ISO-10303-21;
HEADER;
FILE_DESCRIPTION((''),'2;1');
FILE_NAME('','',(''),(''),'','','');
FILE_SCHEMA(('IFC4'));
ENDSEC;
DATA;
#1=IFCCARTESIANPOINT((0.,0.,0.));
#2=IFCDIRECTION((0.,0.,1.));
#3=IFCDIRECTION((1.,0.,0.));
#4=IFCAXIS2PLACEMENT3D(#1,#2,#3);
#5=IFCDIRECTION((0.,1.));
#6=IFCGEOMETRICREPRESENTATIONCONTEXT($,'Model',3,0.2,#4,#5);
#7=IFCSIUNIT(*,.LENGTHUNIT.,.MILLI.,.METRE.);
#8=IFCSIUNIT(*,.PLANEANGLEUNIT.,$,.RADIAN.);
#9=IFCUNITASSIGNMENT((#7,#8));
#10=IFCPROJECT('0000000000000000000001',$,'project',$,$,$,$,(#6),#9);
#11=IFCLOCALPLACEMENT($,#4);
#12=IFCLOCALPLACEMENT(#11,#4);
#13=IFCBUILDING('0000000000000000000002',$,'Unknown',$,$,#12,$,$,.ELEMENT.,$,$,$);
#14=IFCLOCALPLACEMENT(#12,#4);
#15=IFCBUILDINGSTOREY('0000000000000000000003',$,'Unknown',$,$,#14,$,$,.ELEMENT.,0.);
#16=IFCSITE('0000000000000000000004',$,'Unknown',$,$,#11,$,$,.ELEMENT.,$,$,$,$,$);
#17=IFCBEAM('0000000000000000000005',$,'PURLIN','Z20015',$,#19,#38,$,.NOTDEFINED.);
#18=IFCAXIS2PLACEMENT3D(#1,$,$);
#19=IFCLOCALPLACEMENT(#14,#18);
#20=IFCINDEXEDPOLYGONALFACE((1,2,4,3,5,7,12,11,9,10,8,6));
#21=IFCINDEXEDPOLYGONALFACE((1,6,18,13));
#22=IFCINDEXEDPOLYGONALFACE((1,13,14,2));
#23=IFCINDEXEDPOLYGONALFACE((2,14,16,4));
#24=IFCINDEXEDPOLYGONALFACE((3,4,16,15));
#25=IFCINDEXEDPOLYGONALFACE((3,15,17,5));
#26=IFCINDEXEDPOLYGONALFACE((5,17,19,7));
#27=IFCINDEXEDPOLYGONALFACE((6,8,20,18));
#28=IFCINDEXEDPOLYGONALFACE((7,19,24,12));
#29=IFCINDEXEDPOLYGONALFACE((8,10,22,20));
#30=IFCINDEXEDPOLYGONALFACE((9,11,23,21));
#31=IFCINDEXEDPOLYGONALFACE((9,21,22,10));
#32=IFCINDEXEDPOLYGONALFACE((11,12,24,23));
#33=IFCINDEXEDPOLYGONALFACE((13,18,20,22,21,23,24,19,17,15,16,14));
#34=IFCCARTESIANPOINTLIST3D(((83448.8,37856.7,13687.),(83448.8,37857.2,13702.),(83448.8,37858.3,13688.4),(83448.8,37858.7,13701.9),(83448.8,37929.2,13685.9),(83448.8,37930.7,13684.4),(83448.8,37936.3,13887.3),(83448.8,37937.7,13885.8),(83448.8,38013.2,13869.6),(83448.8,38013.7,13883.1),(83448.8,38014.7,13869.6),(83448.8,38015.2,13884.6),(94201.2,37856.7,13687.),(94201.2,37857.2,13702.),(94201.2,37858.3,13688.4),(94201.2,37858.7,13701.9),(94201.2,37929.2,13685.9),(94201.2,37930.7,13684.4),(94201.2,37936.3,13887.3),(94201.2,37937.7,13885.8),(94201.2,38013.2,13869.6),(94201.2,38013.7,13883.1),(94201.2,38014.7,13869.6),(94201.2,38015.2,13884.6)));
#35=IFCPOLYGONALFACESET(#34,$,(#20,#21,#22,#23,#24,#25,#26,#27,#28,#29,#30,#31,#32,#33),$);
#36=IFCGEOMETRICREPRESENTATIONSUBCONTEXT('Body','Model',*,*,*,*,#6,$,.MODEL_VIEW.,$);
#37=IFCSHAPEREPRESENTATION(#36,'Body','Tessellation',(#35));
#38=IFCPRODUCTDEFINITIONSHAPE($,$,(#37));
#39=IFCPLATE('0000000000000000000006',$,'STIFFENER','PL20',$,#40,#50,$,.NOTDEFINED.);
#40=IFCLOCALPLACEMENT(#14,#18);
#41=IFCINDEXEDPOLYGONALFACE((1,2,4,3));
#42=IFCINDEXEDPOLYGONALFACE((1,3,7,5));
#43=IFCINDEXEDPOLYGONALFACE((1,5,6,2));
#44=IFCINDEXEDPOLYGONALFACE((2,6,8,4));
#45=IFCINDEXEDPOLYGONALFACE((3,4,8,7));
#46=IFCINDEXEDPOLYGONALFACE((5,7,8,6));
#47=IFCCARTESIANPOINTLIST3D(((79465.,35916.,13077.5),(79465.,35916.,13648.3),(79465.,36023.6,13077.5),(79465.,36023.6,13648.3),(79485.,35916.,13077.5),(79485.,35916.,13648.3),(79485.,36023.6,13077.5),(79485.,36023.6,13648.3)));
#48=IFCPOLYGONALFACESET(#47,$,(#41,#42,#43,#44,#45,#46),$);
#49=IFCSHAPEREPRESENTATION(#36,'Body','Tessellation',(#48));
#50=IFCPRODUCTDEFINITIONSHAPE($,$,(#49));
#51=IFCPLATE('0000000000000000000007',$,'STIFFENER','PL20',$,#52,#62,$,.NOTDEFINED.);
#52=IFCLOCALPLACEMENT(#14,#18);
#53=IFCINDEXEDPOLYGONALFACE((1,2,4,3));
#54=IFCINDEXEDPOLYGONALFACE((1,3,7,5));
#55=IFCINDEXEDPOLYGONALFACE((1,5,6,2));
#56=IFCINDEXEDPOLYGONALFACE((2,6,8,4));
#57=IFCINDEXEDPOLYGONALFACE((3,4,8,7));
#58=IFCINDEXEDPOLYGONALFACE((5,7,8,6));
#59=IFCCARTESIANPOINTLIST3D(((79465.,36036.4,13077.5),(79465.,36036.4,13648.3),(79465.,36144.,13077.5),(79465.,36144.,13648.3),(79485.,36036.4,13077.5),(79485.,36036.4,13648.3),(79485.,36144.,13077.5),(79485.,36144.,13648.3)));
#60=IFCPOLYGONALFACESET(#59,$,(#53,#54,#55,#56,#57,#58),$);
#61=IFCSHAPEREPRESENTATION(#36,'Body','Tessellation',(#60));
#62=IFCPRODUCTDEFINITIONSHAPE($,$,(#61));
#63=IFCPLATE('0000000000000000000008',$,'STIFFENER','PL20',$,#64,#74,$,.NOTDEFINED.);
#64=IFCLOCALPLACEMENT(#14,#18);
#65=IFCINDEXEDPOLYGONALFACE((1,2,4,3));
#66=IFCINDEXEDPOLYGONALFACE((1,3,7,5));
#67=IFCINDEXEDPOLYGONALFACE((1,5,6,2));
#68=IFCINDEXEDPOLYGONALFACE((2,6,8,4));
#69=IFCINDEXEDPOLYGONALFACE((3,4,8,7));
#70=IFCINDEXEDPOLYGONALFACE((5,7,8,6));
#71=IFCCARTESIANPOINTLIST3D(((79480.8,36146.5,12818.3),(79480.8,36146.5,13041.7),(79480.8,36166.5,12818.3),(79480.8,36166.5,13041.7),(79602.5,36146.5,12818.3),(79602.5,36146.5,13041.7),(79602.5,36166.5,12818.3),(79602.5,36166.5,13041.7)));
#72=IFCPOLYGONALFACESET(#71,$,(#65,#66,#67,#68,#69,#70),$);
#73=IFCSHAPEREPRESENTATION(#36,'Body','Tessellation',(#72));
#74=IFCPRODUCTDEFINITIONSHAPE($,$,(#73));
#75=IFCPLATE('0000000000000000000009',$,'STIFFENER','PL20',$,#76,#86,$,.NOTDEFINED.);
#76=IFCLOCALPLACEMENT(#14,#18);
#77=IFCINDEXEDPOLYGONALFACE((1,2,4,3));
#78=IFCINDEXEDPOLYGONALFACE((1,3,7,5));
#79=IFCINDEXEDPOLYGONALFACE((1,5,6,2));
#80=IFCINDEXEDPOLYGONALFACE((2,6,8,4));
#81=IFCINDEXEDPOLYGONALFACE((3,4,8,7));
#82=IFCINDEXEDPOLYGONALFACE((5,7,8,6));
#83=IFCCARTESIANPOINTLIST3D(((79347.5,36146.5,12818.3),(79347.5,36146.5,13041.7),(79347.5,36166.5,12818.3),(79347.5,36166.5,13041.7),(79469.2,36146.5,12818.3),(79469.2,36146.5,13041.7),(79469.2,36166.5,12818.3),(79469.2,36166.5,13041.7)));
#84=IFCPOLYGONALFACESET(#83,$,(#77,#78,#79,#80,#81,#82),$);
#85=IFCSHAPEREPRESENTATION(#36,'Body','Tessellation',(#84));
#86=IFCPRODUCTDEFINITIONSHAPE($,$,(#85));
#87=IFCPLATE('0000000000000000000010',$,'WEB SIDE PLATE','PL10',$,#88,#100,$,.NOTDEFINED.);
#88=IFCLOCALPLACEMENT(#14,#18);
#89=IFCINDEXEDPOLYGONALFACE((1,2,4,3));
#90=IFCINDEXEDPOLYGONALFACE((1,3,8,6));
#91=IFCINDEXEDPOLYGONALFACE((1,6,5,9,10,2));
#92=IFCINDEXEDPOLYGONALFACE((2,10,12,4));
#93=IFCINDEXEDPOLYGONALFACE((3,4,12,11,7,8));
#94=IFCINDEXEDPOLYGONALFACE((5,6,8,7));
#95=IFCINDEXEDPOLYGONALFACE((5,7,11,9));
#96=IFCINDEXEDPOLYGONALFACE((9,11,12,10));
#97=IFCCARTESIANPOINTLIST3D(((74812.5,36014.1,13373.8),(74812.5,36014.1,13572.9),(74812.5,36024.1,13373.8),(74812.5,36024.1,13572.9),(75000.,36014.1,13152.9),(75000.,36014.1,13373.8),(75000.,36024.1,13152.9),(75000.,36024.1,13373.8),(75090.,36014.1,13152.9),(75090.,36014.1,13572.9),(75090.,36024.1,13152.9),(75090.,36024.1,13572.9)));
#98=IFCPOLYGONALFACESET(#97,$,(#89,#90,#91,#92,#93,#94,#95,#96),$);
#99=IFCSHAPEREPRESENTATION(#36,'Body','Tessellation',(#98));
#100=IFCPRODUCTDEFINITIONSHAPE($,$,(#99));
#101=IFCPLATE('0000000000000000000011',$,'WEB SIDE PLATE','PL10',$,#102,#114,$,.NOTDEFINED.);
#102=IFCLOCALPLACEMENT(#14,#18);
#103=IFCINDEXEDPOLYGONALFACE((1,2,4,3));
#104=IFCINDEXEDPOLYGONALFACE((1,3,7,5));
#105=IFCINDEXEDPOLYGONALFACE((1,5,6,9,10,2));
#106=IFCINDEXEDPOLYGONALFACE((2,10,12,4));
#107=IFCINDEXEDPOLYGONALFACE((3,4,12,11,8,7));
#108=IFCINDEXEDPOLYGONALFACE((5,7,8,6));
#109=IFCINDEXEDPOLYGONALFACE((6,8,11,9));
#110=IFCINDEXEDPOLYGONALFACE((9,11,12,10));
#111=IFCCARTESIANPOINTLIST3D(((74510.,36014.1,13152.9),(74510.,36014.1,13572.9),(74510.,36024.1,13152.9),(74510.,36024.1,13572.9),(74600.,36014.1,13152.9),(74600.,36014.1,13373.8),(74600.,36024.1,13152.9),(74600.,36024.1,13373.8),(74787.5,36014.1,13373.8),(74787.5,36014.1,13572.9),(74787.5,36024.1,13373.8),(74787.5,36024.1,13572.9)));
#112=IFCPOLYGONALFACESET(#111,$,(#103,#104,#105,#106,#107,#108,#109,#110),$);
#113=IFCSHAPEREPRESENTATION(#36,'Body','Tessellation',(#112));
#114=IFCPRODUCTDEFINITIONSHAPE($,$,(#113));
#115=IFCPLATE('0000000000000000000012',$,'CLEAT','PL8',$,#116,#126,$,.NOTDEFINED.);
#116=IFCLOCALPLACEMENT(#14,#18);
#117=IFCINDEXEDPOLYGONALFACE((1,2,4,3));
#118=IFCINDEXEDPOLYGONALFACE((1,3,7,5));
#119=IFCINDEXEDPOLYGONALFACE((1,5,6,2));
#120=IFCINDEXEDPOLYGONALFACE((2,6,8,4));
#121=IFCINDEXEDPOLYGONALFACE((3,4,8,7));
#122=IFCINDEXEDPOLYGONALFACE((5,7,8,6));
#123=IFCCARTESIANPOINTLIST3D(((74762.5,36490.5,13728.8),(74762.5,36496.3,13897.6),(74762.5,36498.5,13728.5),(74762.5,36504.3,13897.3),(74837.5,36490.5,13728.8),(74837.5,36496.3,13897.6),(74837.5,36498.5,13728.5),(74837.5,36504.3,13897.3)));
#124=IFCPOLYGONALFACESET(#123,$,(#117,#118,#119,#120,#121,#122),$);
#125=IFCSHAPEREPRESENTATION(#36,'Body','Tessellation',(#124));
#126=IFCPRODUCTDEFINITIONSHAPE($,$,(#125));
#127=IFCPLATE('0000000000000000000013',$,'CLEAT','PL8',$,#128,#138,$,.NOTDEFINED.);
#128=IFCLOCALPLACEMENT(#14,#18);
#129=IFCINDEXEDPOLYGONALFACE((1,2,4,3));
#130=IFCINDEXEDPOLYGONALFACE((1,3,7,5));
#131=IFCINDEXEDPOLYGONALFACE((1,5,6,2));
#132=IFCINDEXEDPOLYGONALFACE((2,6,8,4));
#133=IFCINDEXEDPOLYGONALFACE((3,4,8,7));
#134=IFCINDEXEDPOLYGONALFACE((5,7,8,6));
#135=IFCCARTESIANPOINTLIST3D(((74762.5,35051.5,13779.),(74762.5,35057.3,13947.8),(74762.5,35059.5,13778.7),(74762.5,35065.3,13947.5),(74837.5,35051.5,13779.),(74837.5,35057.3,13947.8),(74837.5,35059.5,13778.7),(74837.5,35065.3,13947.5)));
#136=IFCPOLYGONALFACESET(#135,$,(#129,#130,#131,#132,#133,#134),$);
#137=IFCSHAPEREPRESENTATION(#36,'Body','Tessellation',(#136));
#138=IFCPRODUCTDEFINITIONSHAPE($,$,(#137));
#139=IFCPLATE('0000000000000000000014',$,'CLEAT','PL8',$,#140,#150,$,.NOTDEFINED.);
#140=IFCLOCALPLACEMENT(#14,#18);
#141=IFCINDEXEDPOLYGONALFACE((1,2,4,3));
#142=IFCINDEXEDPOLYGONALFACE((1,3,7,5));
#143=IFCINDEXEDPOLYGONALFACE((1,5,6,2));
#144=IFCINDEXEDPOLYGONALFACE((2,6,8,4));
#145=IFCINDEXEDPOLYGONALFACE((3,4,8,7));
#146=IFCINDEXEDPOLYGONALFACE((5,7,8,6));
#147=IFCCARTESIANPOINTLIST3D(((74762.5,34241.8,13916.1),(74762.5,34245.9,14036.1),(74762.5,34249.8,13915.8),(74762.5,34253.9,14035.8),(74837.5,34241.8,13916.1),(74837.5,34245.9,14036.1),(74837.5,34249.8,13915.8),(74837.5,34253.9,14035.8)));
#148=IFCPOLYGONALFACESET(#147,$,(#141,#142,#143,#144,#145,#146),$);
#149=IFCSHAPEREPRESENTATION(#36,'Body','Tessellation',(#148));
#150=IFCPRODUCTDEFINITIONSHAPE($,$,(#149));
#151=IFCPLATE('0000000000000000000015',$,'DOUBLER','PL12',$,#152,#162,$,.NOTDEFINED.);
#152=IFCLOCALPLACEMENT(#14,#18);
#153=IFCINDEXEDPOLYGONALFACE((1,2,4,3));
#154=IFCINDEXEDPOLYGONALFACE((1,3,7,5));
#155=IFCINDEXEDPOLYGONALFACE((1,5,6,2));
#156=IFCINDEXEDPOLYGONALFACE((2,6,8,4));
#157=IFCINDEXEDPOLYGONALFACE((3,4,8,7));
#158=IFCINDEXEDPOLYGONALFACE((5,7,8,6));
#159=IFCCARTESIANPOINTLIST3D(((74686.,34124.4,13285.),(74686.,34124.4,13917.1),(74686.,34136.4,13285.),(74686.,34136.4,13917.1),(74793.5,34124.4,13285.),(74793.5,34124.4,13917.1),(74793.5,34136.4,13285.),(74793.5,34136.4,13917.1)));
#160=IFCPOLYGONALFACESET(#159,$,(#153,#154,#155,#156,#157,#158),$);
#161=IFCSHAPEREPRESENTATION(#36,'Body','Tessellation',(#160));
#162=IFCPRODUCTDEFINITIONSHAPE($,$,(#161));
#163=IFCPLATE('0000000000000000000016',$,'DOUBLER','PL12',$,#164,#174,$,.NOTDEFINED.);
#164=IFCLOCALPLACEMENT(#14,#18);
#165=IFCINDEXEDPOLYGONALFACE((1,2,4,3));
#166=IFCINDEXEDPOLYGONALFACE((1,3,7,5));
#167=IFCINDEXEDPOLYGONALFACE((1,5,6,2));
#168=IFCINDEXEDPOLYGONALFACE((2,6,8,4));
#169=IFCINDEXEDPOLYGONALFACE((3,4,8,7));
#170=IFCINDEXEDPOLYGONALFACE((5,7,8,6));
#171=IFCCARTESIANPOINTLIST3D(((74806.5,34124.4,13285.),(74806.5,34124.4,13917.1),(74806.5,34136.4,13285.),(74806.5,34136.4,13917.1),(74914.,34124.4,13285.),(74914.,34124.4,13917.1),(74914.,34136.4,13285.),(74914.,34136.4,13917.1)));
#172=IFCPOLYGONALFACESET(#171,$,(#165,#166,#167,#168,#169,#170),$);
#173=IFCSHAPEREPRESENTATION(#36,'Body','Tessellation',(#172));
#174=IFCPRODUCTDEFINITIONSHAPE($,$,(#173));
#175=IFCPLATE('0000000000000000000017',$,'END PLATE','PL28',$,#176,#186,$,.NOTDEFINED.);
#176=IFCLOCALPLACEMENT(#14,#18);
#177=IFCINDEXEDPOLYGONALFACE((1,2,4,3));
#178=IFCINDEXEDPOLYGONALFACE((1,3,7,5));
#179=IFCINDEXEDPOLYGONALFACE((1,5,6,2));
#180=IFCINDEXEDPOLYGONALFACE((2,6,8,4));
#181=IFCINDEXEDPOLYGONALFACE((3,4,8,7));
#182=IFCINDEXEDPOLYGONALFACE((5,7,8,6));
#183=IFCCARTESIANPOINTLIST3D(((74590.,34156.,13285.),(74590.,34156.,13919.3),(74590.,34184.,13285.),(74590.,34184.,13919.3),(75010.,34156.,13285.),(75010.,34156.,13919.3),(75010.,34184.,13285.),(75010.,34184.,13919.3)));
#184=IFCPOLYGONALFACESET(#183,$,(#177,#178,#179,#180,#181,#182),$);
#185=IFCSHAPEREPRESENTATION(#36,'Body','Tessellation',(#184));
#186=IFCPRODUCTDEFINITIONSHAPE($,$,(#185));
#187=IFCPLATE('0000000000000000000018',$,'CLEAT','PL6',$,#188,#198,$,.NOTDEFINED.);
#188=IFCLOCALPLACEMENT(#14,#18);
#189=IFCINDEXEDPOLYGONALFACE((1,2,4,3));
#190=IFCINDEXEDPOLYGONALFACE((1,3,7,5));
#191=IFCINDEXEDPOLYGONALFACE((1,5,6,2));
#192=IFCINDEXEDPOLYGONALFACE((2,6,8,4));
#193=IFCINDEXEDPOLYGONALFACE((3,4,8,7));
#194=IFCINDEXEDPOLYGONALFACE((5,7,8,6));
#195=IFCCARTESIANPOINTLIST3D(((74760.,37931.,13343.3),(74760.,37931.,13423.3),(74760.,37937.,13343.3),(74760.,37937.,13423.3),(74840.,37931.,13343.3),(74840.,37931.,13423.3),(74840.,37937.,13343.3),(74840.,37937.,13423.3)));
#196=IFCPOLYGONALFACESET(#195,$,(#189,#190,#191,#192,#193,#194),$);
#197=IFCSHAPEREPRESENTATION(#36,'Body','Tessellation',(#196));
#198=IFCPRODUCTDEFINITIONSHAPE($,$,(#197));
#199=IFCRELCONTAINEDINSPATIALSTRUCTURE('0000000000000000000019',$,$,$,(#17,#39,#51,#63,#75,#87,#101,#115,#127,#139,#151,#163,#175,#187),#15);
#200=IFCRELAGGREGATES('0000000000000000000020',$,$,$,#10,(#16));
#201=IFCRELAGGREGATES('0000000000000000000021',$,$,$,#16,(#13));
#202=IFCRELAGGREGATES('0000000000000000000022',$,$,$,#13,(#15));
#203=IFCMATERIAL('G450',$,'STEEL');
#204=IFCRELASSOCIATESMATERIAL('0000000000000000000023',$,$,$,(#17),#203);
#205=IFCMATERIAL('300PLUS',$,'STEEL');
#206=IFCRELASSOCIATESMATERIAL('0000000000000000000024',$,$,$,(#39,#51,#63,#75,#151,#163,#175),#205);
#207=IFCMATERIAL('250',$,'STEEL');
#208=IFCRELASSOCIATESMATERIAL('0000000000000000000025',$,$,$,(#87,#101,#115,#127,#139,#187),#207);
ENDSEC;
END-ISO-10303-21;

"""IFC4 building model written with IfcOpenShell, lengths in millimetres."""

from ifc_helpers import new_model, si_unit, direction, frame, origin_with_axes, place, context, subcontext, project, spatial, line, indexed_curve, outline, extrude, material, element, save


model = new_model("IFC4")

# Units and contexts
model_context = context("Model", 3, precision=0.2, world=origin_with_axes(), true_north=direction((0.0, 1.0)))
body_context = subcontext(model_context, "Body", "Model", "MODEL_VIEW")
ifc_project = project(units=[si_unit("LENGTHUNIT", "METRE", prefix="MILLI"), si_unit("PLANEANGLEUNIT", "RADIAN")], contexts=[model_context])

# Site, building, storey
site_placement = place(None, origin_with_axes())
site = spatial("IfcSite", under=ifc_project, at=site_placement, Name="Unknown", CompositionType="ELEMENT")
building_placement = place(site_placement, origin_with_axes())
building = spatial("IfcBuilding", under=site, at=building_placement, Name="Unknown", CompositionType="ELEMENT")
storey_placement = place(building_placement, origin_with_axes())
storey = spatial("IfcBuildingStorey", under=building, at=storey_placement, Name="Unknown", CompositionType="ELEMENT", Elevation=0.0)

# Beam
ifc_material_1 = material(Name="300PLUS", Category="STEEL")
ifc_material_2 = material(Name="G450", Category="STEEL")
for number, where, z_axis, x_axis, name in (
    (1, (83448.8, 37933.5, 13785.9), (0.0, -0.999391, 0.034899), (1.0, 0.0, 0.0), "PURLIN"),
):
    element("IfcBeam", number, at=place(storey_placement, frame(where, z_axis=z_axis, x_axis=x_axis)), inside=storey, material=ifc_material_2, Name=name, Description="Z20015", PredefinedType="NOTDEFINED", context=body_context, shape_type="SolidModel", body=[
        extrude(outline(indexed_curve([(73.2, -101.5), (73.2, -86.5), (71.8, -86.5), (71.8, -100.0), (0.8, -100.0), (0.8, 101.5), (-78.2, 101.5), (-78.2, 86.5), (-76.8, 86.5), (-76.8, 100.0), (-0.8, 100.0), (-0.8, -101.5)], segments=[line(1, 2, 3, 4, 5, 6, 7, 8, 9, 10, 11, 12, 1)])), frame((0.0, 0.0, 0.0), z_axis=(-1.0, 0.0, 0.0), x_axis=(0.0, 0.0, 1.0)), (0.0, 0.0, -1.0), 10752.4),
    ])

# Plates
for number, where, z_axis, x_axis, name in (
    (2, (79475.0, 36023.6, 13077.5), (1.0, 0.0, 0.0), (0.0, 0.0, 1.0), "STIFFENER"),
    (3, (79475.0, 36144.0, 13077.5), (1.0, 0.0, 0.0), (0.0, 0.0, 1.0), "STIFFENER"),
):
    element("IfcPlate", number, at=place(storey_placement, frame(where, z_axis=z_axis, x_axis=x_axis)), inside=storey, material=ifc_material_1, Name=name, Description="PL20", PredefinedType="NOTDEFINED", context=body_context, shape_type="SolidModel", body=[
        extrude(outline(indexed_curve([(0.0, 0.0), (570.8, 0.0), (570.8, 107.6), (0.0, 107.6)], segments=[line(1, 2, 3, 4, 1)])), frame((0.0, 0.0, 10.0), z_axis=(0.0, 0.0, 1.0), x_axis=(1.0, 0.0, 0.0)), (0.0, 0.0, -1.0), 20.0),
    ])
for number, where, z_axis, x_axis, name in (
    (4, (79480.8, 36156.5, 12818.3), (0.0, 1.0, 0.0), (0.0, 0.0, 1.0), "STIFFENER"),
    (5, (79347.5, 36156.5, 12818.3), (0.0, 1.0, 0.0), (0.0, 0.0, 1.0), "STIFFENER"),
):
    element("IfcPlate", number, at=place(storey_placement, frame(where, z_axis=z_axis, x_axis=x_axis)), inside=storey, material=ifc_material_1, Name=name, Description="PL20", PredefinedType="NOTDEFINED", context=body_context, shape_type="SolidModel", body=[
        extrude(outline(indexed_curve([(0.0, 0.0), (223.4, 0.0), (223.4, 121.7), (0.0, 121.7)], segments=[line(1, 2, 3, 4, 1)])), frame((0.0, 0.0, 10.0), z_axis=(0.0, 0.0, 1.0), x_axis=(1.0, 0.0, 0.0)), (0.0, 0.0, -1.0), 20.0),
    ])
ifc_material_3 = material(Name="250", Category="STEEL")
plate_1_placement = place(storey_placement, frame((75090.0, 36019.1, 13152.9), z_axis=(0.0, -1.0, 0.0), x_axis=(0.0, 0.0, 1.0)))
element("IfcPlate", 6, at=plate_1_placement, inside=storey, material=ifc_material_3, Name="WEB SIDE PLATE", Description="PL10", PredefinedType="NOTDEFINED", context=body_context, shape_type="SolidModel", body=[
    extrude(outline(indexed_curve([(0.0, 0.0), (420.0, 0.0), (420.0, 277.5), (220.9, 277.5), (220.9, 90.0), (0.0, 90.0)], segments=[line(1, 2, 3, 4, 5, 6, 1)])), frame((0.0, 0.0, 5.0), z_axis=(0.0, 0.0, 1.0), x_axis=(1.0, 0.0, 0.0)), (0.0, 0.0, -1.0), 10.0),
])
plate_2_placement = place(storey_placement, frame((74600.0, 36019.1, 13152.9), z_axis=(0.0, -1.0, 0.0), x_axis=(0.0, 0.0, 1.0)))
element("IfcPlate", 7, at=plate_2_placement, inside=storey, material=ifc_material_3, Name="WEB SIDE PLATE", Description="PL10", PredefinedType="NOTDEFINED", context=body_context, shape_type="SolidModel", body=[
    extrude(outline(indexed_curve([(0.0, 0.0), (220.9, 0.0), (220.9, -187.5), (420.0, -187.5), (420.0, 90.0), (0.0, 90.0)], segments=[line(1, 2, 3, 4, 5, 6, 1)])), frame((0.0, 0.0, 5.0), z_axis=(0.0, 0.0, 1.0), x_axis=(1.0, 0.0, 0.0)), (0.0, 0.0, -1.0), 10.0),
])
for number, where, z_axis, x_axis, name in (
    (8, (74762.5, 36494.5, 13728.6), (0.0, -0.99941, 0.03434), (1.0, 0.0, 0.0), "CLEAT"),
    (9, (74762.5, 35055.5, 13778.8), (0.0, -0.99941, 0.03434), (1.0, 0.0, 0.0), "CLEAT"),
):
    element("IfcPlate", number, at=place(storey_placement, frame(where, z_axis=z_axis, x_axis=x_axis)), inside=storey, material=ifc_material_3, Name=name, Description="PL8", PredefinedType="NOTDEFINED", context=body_context, shape_type="SolidModel", body=[
        extrude(outline(indexed_curve([(0.0, 0.0), (75.0, 0.0), (75.0, 168.9), (0.0, 168.9)], segments=[line(1, 2, 3, 4, 1)])), frame((0.0, 0.0, 4.0), z_axis=(0.0, 0.0, 1.0), x_axis=(1.0, 0.0, 0.0)), (0.0, 0.0, -1.0), 8.0),
    ])
plate_3_placement = place(storey_placement, frame((74762.5, 34245.8, 13915.9), z_axis=(0.0, -0.999417, 0.034147), x_axis=(1.0, 0.0, 0.0)))
element("IfcPlate", 10, at=plate_3_placement, inside=storey, material=ifc_material_3, Name="CLEAT", Description="PL8", PredefinedType="NOTDEFINED", context=body_context, shape_type="SolidModel", body=[
    extrude(outline(indexed_curve([(0.0, 0.0), (75.0, 0.0), (75.0, 120.1), (0.0, 120.1)], segments=[line(1, 2, 3, 4, 1)])), frame((0.0, 0.0, 4.0), z_axis=(0.0, 0.0, 1.0), x_axis=(1.0, 0.0, 0.0)), (0.0, 0.0, -1.0), 8.0),
])
for number, where, z_axis, x_axis, name in (
    (11, (74793.5, 34130.4, 13917.1), (0.0, -1.0, 0.0), (-1.0, 0.0, 0.0), "DOUBLER"),
    (12, (74914.0, 34130.4, 13917.1), (0.0, -1.0, 0.0), (-1.0, 0.0, 0.0), "DOUBLER"),
):
    element("IfcPlate", number, at=place(storey_placement, frame(where, z_axis=z_axis, x_axis=x_axis)), inside=storey, material=ifc_material_1, Name=name, Description="PL12", PredefinedType="NOTDEFINED", context=body_context, shape_type="SolidModel", body=[
        extrude(outline(indexed_curve([(0.0, 0.0), (107.5, 0.0), (107.5, 632.1), (0.0, 632.1)], segments=[line(1, 2, 3, 4, 1)])), frame((0.0, 0.0, 6.0), z_axis=(0.0, 0.0, 1.0), x_axis=(1.0, 0.0, 0.0)), (0.0, 0.0, -1.0), 12.0),
    ])
plate_4_placement = place(storey_placement, frame((74590.0, 34170.0, 13919.3), z_axis=(0.0, 1.0, 0.0), x_axis=(1.0, 0.0, 0.0)))
element("IfcPlate", 13, at=plate_4_placement, inside=storey, material=ifc_material_1, Name="END PLATE", Description="PL28", PredefinedType="NOTDEFINED", context=body_context, shape_type="SolidModel", body=[
    extrude(outline(indexed_curve([(0.0, 0.0), (420.0, 0.0), (420.0, 634.3), (0.0, 634.3)], segments=[line(1, 2, 3, 4, 1)])), frame((0.0, 0.0, 14.0), z_axis=(0.0, 0.0, 1.0), x_axis=(1.0, 0.0, 0.0)), (0.0, 0.0, -1.0), 28.0),
])
plate_5_placement = place(storey_placement, frame((74760.0, 37934.0, 13343.3), z_axis=(0.0, -1.0, 0.0), x_axis=(1.0, 0.0, 0.0)))
element("IfcPlate", 14, at=plate_5_placement, inside=storey, material=ifc_material_3, Name="CLEAT", Description="PL6", PredefinedType="NOTDEFINED", context=body_context, shape_type="SolidModel", body=[
    extrude(outline(indexed_curve([(0.0, 0.0), (80.0, 0.0), (80.0, 80.0), (0.0, 80.0)], segments=[line(1, 2, 3, 4, 1)])), frame((0.0, 0.0, 3.0), z_axis=(0.0, 0.0, 1.0), x_axis=(1.0, 0.0, 0.0)), (0.0, 0.0, -1.0), 6.0),
])

save(model, "model.ifc")
